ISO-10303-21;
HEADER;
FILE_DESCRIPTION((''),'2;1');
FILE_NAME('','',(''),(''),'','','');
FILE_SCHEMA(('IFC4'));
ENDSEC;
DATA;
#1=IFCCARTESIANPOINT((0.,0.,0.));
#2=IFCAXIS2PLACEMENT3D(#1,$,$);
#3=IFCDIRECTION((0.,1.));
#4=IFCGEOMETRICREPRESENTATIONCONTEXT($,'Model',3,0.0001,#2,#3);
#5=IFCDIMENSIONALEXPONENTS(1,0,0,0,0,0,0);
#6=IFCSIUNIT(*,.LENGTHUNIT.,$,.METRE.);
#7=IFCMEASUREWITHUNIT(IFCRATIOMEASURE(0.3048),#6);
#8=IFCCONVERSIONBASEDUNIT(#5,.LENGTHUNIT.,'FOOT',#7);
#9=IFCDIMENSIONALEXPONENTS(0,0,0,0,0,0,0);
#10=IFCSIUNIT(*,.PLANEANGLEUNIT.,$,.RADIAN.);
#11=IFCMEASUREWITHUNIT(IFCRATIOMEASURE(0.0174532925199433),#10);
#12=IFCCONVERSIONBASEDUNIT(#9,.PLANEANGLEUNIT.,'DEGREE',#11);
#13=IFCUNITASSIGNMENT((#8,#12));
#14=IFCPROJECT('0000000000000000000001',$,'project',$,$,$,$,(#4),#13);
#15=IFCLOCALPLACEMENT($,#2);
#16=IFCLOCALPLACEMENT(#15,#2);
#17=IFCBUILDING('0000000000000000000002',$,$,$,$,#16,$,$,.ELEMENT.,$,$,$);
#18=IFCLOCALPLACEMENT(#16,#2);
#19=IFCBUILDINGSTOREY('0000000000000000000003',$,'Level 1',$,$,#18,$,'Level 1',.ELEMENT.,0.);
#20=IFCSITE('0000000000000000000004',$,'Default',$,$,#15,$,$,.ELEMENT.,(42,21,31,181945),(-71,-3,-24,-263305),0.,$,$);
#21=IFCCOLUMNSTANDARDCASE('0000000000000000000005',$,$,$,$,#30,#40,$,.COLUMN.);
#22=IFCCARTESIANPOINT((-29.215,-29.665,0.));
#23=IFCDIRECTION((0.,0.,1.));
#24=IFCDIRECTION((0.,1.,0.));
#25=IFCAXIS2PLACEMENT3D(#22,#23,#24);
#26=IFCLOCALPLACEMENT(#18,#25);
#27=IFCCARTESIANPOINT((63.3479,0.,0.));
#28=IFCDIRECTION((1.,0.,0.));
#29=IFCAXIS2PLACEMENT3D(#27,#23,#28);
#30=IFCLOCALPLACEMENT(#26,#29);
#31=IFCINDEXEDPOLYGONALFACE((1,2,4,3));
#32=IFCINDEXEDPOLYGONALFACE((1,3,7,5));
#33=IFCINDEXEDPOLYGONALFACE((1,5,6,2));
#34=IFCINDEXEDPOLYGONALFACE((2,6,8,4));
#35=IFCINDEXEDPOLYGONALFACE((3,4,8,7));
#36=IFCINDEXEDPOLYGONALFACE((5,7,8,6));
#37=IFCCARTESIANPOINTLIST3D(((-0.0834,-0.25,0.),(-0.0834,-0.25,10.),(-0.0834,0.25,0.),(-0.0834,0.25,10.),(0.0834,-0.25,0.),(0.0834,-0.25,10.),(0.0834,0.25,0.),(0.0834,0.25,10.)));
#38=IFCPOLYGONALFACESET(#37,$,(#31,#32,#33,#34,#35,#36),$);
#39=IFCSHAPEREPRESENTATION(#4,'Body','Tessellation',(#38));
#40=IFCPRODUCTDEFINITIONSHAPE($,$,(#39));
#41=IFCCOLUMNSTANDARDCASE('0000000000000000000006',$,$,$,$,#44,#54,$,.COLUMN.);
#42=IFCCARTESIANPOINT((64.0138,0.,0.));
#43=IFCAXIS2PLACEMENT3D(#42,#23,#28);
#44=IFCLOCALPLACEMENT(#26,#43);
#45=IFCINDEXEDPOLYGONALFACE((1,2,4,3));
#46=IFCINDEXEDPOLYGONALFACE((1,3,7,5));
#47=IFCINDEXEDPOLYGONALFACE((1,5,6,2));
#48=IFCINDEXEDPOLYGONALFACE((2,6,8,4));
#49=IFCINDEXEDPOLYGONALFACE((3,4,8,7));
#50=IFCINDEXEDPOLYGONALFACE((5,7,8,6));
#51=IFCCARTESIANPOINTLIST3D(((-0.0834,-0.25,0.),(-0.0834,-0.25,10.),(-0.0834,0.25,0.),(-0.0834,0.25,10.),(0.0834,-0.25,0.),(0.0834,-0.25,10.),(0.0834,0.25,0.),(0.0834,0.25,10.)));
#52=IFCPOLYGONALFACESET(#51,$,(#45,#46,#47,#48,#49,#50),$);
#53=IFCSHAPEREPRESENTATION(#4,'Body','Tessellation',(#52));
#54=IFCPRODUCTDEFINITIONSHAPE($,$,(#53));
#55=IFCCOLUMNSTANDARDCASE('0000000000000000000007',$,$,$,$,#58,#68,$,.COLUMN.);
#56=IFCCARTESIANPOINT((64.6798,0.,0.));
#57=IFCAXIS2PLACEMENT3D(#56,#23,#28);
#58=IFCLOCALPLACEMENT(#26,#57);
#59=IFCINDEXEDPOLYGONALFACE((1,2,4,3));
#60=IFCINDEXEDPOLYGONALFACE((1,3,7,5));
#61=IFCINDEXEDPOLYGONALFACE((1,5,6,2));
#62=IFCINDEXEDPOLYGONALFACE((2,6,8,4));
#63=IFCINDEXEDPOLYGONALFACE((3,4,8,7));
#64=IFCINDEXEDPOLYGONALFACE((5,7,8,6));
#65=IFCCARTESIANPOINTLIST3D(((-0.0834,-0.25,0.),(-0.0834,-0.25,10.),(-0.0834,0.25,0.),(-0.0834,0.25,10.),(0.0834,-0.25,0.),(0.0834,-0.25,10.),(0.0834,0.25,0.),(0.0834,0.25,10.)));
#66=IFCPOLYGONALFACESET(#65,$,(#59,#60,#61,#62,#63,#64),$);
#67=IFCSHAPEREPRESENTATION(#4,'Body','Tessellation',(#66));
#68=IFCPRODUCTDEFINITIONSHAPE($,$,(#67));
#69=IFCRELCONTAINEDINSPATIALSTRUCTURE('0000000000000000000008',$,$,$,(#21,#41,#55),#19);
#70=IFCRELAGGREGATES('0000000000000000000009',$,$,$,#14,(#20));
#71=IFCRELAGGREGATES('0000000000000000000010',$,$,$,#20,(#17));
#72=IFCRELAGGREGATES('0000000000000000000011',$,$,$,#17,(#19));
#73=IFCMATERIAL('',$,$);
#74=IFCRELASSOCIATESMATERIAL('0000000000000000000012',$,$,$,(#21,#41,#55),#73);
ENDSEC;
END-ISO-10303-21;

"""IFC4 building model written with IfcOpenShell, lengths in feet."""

from ifc_helpers import new_model, entity, si_unit, converted_unit, direction, frame, origin, place, context, project, spatial, rectangle, extrude, material, element, save


model = new_model("IFC4")

# Units and contexts
model_context = context("Model", 3, precision=0.0001, world=origin(), true_north=direction((0.0, 1.0)))
ifc_project = project(units=[converted_unit("LENGTHUNIT", "FOOT", entity("IfcRatioMeasure", 0.3048), si_unit("LENGTHUNIT", "METRE"), dimensions=[1, 0, 0, 0, 0, 0, 0]), converted_unit("PLANEANGLEUNIT", "DEGREE", entity("IfcRatioMeasure", 0.0174532925199433), si_unit("PLANEANGLEUNIT", "RADIAN"), dimensions=[0, 0, 0, 0, 0, 0, 0])], contexts=[model_context])

# Site, building, storey
site_placement = place(None, origin())
site = spatial("IfcSite", under=ifc_project, at=site_placement, Name="Default", CompositionType="ELEMENT", RefLatitude=(42, 21, 31, 181945), RefLongitude=(-71, -3, -24, -263305), RefElevation=0.0)
building_placement = place(site_placement, origin())
building = spatial("IfcBuilding", under=site, at=building_placement, CompositionType="ELEMENT")
storey_placement = place(building_placement, origin())
storey = spatial("IfcBuildingStorey", under=building, at=storey_placement, Name="Level 1", LongName="Level 1", CompositionType="ELEMENT", Elevation=0.0)

# Columns
ifc_material = material(Name="")
placement = place(storey_placement, frame((-29.215, -29.665, 0.0), z_axis=(0.0, 0.0, 1.0), x_axis=(0.0, 1.0, 0.0)))
for number, where, z_axis, x_axis in (
    (1, (63.3479, 0.0, 0.0), (0.0, 0.0, 1.0), (1.0, 0.0, 0.0)),
    (2, (64.0138, 0.0, 0.0), (0.0, 0.0, 1.0), (1.0, 0.0, 0.0)),
    (3, (64.6798, 0.0, 0.0), (0.0, 0.0, 1.0), (1.0, 0.0, 0.0)),
):
    element("IfcColumnStandardCase", number, at=place(placement, frame(where, z_axis=z_axis, x_axis=x_axis)), inside=storey, material=ifc_material, PredefinedType="COLUMN", context=model_context, shape_type="SweptSolid", body=[
        extrude(rectangle(XDim=0.1667, YDim=0.5), origin(), (0.0, 0.0, 1.0), 10.0),
    ])

save(model, "model.ifc")
